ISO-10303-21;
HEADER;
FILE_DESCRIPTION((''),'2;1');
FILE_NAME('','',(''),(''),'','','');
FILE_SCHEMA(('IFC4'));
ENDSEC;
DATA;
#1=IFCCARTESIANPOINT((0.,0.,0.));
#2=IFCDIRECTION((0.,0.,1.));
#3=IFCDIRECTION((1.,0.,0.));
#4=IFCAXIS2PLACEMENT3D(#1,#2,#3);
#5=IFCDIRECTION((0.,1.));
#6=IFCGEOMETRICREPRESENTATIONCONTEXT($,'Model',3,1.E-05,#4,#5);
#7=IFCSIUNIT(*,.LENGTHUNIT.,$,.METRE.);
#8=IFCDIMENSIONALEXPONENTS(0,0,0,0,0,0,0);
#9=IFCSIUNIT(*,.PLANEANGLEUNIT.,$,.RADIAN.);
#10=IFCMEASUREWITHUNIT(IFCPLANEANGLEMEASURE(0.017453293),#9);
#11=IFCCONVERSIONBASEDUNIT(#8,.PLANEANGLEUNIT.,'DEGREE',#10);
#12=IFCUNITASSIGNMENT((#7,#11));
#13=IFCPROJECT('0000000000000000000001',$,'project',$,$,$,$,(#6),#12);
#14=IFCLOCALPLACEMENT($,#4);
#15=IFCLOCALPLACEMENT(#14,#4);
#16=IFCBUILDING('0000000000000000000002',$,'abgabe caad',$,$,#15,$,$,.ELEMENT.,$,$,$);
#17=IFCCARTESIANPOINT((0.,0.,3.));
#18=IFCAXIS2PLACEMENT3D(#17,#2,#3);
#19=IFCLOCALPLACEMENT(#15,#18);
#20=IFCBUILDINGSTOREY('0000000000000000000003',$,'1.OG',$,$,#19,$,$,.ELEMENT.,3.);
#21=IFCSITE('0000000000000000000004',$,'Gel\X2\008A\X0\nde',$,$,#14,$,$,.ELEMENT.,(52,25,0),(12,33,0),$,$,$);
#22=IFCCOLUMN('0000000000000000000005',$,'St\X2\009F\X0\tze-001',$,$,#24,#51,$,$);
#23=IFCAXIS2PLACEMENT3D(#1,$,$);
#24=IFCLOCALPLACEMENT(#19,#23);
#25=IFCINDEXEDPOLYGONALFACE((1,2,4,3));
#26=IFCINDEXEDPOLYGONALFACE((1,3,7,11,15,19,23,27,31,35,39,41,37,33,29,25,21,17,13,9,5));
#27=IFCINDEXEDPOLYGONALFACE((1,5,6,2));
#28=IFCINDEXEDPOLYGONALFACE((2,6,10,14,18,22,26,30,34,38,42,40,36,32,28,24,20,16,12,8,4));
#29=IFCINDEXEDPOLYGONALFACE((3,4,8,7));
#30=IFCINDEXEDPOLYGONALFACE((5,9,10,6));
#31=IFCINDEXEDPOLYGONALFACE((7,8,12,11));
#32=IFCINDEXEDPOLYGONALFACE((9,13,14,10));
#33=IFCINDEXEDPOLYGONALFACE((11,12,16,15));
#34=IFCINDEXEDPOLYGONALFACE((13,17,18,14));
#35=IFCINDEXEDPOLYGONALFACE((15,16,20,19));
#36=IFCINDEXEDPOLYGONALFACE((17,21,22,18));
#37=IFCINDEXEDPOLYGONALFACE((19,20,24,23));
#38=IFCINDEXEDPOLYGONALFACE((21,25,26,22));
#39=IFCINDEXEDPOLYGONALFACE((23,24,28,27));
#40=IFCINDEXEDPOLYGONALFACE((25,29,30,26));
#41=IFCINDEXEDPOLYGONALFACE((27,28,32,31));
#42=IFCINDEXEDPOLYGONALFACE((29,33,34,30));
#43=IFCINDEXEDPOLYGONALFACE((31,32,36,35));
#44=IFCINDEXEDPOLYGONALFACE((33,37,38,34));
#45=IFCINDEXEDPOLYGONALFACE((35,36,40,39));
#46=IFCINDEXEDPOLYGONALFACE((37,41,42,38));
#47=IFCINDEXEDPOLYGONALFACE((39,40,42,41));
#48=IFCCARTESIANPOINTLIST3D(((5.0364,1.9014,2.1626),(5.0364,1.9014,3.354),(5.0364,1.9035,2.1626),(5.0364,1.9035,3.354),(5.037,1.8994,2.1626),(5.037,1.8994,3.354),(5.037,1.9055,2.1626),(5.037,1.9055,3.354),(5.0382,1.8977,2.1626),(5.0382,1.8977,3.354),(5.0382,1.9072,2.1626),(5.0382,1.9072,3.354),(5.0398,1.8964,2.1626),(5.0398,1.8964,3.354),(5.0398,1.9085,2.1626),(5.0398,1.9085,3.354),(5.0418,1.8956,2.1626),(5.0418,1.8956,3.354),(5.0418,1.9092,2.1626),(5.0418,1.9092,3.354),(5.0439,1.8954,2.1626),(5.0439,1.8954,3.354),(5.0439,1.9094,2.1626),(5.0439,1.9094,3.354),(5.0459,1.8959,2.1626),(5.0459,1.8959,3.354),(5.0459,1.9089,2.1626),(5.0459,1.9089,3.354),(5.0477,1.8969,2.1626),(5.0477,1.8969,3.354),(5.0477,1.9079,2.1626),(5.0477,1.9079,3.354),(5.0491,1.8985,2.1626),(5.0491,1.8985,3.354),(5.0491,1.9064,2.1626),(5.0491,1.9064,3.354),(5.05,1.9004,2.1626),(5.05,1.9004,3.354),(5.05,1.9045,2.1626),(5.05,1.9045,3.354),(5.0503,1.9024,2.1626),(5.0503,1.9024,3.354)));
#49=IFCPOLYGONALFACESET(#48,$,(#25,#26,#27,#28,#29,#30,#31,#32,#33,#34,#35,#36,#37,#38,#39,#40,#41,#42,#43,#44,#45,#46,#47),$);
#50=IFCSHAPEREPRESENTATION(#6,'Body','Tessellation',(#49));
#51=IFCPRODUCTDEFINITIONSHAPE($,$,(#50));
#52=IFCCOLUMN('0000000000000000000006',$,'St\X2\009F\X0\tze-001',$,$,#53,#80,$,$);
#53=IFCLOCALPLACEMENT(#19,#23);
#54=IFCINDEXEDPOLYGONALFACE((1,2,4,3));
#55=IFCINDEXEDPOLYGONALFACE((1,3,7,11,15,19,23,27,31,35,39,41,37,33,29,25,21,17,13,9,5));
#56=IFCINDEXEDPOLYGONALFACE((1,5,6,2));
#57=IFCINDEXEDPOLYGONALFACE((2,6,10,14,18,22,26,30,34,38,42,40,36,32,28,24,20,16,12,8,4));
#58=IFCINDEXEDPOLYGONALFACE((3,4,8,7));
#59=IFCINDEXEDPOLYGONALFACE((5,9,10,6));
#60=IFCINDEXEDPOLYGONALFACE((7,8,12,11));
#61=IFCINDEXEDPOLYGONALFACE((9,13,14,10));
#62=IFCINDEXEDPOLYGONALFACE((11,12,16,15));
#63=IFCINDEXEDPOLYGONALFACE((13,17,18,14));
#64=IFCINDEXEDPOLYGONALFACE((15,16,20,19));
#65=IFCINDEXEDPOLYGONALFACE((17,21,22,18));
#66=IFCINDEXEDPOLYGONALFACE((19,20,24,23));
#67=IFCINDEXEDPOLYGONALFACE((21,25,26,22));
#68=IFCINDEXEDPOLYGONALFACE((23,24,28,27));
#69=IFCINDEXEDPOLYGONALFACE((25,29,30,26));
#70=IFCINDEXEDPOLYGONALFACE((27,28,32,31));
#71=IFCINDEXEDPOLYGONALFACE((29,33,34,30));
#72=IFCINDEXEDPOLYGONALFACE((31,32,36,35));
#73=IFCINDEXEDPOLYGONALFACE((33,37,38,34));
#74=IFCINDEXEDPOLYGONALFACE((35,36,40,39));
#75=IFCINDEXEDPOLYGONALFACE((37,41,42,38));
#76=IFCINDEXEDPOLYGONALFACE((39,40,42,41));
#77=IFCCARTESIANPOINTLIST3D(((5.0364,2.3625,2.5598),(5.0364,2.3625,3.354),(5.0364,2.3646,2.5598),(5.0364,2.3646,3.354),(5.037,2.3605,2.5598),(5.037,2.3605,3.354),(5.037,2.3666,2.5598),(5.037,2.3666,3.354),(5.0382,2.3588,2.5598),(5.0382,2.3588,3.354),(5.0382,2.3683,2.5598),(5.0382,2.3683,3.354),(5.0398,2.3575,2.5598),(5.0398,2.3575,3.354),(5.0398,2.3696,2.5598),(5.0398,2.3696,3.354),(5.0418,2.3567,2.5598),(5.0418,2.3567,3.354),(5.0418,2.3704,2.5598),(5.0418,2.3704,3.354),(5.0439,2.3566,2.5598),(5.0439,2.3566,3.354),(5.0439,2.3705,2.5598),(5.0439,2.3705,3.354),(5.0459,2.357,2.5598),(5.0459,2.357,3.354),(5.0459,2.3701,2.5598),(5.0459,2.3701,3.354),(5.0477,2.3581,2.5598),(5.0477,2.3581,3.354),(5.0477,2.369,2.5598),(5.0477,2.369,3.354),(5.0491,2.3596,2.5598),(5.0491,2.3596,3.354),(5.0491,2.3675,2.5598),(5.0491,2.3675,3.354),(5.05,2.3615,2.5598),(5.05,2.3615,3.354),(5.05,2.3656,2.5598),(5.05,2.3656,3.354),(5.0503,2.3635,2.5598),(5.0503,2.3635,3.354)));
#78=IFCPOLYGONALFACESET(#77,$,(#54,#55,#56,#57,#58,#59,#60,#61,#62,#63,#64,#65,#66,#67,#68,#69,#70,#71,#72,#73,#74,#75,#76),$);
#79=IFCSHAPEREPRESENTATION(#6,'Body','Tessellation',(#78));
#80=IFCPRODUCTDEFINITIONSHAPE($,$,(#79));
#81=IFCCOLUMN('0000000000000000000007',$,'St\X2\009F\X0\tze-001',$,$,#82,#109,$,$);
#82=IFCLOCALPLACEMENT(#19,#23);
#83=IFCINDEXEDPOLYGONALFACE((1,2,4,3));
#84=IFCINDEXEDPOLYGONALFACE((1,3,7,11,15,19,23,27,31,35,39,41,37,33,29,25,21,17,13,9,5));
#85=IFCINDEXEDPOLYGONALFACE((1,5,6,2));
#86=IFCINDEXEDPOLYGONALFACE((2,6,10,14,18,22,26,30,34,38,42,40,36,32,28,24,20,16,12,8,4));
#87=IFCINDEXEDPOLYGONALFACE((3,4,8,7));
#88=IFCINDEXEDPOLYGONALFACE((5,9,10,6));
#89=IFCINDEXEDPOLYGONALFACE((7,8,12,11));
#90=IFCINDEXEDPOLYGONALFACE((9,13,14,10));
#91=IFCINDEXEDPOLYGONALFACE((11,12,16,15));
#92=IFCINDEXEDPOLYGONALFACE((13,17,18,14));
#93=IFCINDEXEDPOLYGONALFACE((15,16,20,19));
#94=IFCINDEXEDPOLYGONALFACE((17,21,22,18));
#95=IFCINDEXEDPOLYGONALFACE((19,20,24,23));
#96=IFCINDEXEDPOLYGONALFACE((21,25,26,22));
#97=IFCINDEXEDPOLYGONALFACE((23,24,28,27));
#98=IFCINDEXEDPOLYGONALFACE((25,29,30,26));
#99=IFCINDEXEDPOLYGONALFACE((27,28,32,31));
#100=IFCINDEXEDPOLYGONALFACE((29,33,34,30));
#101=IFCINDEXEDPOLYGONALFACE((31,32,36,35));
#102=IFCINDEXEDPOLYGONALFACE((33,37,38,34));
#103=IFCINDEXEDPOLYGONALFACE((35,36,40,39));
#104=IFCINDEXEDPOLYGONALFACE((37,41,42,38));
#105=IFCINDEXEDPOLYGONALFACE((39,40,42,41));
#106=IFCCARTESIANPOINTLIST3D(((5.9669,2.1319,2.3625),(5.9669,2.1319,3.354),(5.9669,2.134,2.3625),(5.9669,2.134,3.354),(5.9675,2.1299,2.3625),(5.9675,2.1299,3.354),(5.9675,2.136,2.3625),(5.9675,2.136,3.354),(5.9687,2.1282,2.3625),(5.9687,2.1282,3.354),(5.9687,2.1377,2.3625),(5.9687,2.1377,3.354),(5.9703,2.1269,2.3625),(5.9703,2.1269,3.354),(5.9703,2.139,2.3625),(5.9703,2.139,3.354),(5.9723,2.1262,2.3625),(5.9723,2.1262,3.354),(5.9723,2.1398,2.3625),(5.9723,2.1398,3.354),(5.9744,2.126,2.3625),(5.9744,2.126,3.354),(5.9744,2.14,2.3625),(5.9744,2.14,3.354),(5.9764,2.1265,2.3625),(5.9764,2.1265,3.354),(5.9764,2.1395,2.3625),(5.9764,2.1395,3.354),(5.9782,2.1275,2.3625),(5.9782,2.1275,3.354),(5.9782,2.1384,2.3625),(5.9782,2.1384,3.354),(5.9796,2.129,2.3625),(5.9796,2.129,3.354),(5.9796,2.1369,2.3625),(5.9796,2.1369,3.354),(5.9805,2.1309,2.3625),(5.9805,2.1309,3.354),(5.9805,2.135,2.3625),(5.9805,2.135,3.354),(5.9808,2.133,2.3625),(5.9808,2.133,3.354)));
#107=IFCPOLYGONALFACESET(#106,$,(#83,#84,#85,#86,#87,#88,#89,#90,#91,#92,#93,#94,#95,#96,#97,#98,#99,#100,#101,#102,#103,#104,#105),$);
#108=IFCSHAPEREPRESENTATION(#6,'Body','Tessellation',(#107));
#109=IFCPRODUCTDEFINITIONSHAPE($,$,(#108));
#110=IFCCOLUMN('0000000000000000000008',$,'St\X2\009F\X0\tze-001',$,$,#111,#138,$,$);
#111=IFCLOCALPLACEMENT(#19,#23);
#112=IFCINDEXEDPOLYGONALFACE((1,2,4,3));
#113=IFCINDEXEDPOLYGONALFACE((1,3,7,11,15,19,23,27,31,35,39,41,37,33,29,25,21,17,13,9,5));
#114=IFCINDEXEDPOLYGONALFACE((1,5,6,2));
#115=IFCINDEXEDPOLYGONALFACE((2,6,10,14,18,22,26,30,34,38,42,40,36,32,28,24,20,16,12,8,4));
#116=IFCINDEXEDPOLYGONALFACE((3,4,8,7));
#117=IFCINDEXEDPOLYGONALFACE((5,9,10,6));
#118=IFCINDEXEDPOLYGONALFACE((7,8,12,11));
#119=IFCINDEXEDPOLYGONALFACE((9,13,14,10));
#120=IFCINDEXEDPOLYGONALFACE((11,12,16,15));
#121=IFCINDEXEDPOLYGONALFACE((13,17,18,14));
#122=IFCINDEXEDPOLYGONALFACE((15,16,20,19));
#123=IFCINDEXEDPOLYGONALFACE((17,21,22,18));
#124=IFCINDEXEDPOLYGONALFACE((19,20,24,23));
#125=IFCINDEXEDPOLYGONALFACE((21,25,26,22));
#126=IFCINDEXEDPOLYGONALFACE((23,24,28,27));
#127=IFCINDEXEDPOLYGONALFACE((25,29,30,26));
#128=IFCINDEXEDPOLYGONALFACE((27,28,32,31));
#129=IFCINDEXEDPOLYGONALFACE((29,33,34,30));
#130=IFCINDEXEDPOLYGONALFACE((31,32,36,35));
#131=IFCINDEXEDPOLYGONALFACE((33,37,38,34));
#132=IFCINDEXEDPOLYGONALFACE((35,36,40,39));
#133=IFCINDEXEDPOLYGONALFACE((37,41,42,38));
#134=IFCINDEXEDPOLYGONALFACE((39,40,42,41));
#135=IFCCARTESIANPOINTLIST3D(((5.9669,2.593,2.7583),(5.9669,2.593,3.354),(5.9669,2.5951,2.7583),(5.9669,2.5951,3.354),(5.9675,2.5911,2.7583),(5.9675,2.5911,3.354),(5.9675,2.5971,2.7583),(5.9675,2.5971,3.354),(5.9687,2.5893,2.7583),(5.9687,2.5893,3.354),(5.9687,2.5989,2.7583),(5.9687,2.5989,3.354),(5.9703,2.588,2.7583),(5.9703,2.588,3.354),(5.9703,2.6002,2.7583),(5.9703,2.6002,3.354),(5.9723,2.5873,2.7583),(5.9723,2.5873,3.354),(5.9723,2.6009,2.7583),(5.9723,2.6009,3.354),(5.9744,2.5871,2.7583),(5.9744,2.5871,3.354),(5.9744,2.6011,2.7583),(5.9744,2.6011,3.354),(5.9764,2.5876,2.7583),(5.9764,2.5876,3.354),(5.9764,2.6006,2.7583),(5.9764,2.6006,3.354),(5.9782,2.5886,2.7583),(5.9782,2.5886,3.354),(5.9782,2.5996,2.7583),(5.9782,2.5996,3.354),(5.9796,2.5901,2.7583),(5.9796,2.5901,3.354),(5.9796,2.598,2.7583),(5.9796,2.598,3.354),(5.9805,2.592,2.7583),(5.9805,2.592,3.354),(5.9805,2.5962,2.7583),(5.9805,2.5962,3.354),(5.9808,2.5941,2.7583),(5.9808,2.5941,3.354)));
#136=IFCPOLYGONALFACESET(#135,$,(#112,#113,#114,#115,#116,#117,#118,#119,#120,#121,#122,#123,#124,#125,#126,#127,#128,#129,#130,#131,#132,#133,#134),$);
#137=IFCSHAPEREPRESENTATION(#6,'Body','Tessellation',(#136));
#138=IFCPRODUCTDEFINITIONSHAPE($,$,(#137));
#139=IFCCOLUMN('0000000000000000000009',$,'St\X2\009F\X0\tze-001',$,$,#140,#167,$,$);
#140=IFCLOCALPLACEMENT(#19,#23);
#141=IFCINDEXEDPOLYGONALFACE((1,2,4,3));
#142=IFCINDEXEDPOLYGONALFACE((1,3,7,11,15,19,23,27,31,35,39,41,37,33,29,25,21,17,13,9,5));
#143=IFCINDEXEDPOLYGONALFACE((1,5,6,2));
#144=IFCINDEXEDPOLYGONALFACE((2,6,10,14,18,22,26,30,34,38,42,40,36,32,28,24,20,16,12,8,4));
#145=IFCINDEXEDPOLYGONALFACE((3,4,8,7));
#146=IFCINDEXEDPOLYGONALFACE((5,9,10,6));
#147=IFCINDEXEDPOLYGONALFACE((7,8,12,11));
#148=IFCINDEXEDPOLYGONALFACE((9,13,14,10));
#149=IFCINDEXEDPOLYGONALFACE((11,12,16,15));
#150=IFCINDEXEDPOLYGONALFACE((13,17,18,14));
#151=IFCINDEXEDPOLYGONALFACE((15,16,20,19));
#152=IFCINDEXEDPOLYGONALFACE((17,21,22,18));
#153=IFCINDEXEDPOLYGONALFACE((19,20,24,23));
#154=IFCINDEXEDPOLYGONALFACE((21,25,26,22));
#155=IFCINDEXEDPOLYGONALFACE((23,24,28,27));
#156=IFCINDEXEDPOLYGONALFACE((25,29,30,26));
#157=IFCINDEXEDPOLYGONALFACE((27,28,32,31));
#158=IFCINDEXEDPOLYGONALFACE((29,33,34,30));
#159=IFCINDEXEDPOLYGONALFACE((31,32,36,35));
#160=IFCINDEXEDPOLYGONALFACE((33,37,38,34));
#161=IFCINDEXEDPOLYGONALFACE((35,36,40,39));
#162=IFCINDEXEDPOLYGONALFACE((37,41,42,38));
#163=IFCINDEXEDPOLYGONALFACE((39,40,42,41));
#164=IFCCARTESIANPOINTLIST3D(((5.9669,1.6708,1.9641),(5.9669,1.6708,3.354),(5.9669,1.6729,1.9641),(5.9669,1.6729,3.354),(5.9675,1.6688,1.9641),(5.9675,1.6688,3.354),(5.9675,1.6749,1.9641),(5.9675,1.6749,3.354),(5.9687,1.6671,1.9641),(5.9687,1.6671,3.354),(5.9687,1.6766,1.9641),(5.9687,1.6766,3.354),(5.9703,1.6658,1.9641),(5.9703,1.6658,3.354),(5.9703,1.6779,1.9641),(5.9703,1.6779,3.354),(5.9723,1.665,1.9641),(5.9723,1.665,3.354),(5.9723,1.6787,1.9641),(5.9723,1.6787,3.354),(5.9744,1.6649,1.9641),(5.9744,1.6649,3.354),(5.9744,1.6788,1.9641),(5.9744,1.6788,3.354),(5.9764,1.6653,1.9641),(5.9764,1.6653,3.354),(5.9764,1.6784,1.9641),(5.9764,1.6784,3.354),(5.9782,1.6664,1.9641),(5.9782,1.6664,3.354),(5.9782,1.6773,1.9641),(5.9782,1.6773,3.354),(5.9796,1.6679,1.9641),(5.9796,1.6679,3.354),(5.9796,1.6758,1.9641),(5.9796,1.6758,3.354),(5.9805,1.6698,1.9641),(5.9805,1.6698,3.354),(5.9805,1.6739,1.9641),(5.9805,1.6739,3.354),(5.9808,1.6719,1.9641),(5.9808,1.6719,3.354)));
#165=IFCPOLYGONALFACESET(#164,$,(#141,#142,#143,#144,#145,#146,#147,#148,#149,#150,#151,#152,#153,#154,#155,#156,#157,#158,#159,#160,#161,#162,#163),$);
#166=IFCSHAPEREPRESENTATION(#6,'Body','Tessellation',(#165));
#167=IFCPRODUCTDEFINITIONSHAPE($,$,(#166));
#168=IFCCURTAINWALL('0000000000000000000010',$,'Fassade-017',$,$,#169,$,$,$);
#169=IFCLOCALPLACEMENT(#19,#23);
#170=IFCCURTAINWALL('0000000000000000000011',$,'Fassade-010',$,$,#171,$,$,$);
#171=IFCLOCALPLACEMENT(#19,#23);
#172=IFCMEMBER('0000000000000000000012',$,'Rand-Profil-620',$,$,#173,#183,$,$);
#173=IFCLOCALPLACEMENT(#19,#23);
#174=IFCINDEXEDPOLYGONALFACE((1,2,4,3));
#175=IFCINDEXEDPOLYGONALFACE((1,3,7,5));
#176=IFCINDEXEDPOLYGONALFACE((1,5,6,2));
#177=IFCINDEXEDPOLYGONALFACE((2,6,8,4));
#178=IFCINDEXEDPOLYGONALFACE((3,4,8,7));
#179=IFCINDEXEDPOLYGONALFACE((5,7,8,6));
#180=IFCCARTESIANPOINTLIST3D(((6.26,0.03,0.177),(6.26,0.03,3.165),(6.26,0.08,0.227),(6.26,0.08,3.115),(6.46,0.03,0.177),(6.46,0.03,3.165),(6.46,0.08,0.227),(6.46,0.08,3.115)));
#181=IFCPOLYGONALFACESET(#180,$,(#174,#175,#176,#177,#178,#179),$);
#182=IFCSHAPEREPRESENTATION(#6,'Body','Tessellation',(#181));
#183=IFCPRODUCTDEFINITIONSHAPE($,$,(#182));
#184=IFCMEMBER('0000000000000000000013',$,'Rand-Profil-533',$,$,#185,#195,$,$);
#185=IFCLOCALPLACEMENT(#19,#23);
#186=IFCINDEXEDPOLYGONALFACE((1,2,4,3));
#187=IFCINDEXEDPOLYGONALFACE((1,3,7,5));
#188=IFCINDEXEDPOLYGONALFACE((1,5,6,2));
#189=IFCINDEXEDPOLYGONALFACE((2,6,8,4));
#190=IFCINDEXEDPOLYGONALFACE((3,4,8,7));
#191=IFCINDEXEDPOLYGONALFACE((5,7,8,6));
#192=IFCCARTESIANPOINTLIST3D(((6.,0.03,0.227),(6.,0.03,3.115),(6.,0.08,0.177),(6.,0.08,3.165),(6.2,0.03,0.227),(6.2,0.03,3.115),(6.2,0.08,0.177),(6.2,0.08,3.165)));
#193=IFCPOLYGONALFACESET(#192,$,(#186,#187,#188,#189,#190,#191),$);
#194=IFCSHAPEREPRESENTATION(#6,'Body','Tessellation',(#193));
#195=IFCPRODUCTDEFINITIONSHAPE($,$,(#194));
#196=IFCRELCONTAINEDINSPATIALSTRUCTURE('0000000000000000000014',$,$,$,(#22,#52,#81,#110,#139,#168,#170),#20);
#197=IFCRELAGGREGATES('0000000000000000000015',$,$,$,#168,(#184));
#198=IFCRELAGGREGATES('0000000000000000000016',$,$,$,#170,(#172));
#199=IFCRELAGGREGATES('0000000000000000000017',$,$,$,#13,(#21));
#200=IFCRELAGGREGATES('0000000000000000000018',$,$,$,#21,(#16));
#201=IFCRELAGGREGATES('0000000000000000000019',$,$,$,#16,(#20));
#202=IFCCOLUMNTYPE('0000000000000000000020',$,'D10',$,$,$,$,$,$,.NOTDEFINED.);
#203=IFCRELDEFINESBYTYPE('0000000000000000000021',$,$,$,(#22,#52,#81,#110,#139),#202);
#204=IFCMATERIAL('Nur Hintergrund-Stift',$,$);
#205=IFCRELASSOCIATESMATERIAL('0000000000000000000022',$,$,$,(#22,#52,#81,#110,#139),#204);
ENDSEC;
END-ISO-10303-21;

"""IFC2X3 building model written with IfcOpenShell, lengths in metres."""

from ifc_helpers import new_model, entity, si_unit, converted_unit, direction, frame, origin_with_axes, origin_2d_with_axis, place, context, project, spatial, polyline, circle, outline, extrude, clip, halfspace, material, type_object, element, aggregate, save


model = new_model("IFC2X3")

# Units and contexts
model_context = context("Model", 3, precision=1e-05, world=origin_with_axes(), true_north=direction((0.0, 1.0)))
ifc_project = project(units=[si_unit("LENGTHUNIT", "METRE"), converted_unit("PLANEANGLEUNIT", "DEGREE", entity("IfcPlaneAngleMeasure", 0.017453293), si_unit("PLANEANGLEUNIT", "RADIAN"), dimensions=[0, 0, 0, 0, 0, 0, 0])], contexts=[model_context])

# Site, building, storey
site_placement = place(None, origin_with_axes())
site = spatial("IfcSite", under=ifc_project, at=site_placement, Name="Gel\u008ande", CompositionType="ELEMENT", RefLatitude=(52, 25, 0), RefLongitude=(12, 33, 0))
building_placement = place(site_placement, origin_with_axes())
building = spatial("IfcBuilding", under=site, at=building_placement, Name="abgabe caad", CompositionType="ELEMENT")
storey_placement = place(building_placement, frame((0.0, 0.0, 3.0), z_axis=(0.0, 0.0, 1.0), x_axis=(1.0, 0.0, 0.0)))
storey = spatial("IfcBuildingStorey", under=building, at=storey_placement, Name="1.OG", CompositionType="ELEMENT", Elevation=3.0)

# Columns
ifc_material_1 = material(Name="Nur Hintergrund-Stift")
column_type = type_object("IfcColumnType", Name="D10", PredefinedType="NOTDEFINED")
column_1_placement = place(storey_placement, frame((5.0433, 1.9024, 2.1626), z_axis=(0.0, 0.0, 1.0), x_axis=(1.0, 0.0, 0.0)))
element("IfcColumn", 1, at=column_1_placement, inside=storey, type_object=column_type, material=ifc_material_1, Name="St\u009ftze-001", context=model_context, shape_type="SweptSolid", body=[
    extrude(circle(Radius=0.007, at=origin_2d_with_axis()), origin_with_axes(), (0.0, 0.0, 1.0), 1.1914),
])
column_2_placement = place(storey_placement, frame((5.0433, 2.3635, 2.5598), z_axis=(0.0, 0.0, 1.0), x_axis=(1.0, 0.0, 0.0)))
element("IfcColumn", 2, at=column_2_placement, inside=storey, type_object=column_type, material=ifc_material_1, Name="St\u009ftze-001", context=model_context, shape_type="SweptSolid", body=[
    extrude(circle(Radius=0.007, at=origin_2d_with_axis()), origin_with_axes(), (0.0, 0.0, 1.0), 0.7943),
])
column_3_placement = place(storey_placement, frame((5.9738, 2.133, 2.3625), z_axis=(0.0, 0.0, 1.0), x_axis=(1.0, 0.0, 0.0)))
element("IfcColumn", 3, at=column_3_placement, inside=storey, type_object=column_type, material=ifc_material_1, Name="St\u009ftze-001", context=model_context, shape_type="SweptSolid", body=[
    extrude(circle(Radius=0.007, at=origin_2d_with_axis()), origin_with_axes(), (0.0, 0.0, 1.0), 0.9915),
])
column_4_placement = place(storey_placement, frame((5.9738, 2.5941, 2.7583), z_axis=(0.0, 0.0, 1.0), x_axis=(1.0, 0.0, 0.0)))
element("IfcColumn", 4, at=column_4_placement, inside=storey, type_object=column_type, material=ifc_material_1, Name="St\u009ftze-001", context=model_context, shape_type="SweptSolid", body=[
    extrude(circle(Radius=0.007, at=origin_2d_with_axis()), origin_with_axes(), (0.0, 0.0, 1.0), 0.5957),
])
column_5_placement = place(storey_placement, frame((5.9738, 1.6719, 1.9641), z_axis=(0.0, 0.0, 1.0), x_axis=(1.0, 0.0, 0.0)))
element("IfcColumn", 5, at=column_5_placement, inside=storey, type_object=column_type, material=ifc_material_1, Name="St\u009ftze-001", context=model_context, shape_type="SweptSolid", body=[
    extrude(circle(Radius=0.007, at=origin_2d_with_axis()), origin_with_axes(), (0.0, 0.0, 1.0), 1.3899),
])

# Curtain wall
curtain_wall_1_placement = place(storey_placement, frame((5.595, 0.055, 0.202), z_axis=(0.0, 0.0, 1.0), x_axis=(1.0, 0.0, 0.0)))
curtain_wall_1 = element("IfcCurtainWall", 6, at=curtain_wall_1_placement, inside=storey, Name="Fassade-017")

# Curtain wall
curtain_wall_2_placement = place(storey_placement, frame((9.205, 0.055, 0.202), z_axis=(0.0, 0.0, 1.0), x_axis=(1.0, 0.0, 0.0)))
curtain_wall_2 = element("IfcCurtainWall", 7, at=curtain_wall_2_placement, inside=storey, Name="Fassade-010")

# Members
member_1_placement = place(curtain_wall_2_placement, frame((-2.8, 0.0, 0.0), z_axis=(0.0, 0.0, 1.0), x_axis=(0.0, -1.0, 0.0)))
member_1 = element("IfcMember", 8, at=member_1_placement, Name="Rand-Profil-620", context=model_context, shape_type="Clipping", body=[
    clip(clip(extrude(outline(polyline([(-0.145, -0.025), (0.055, -0.025), (0.055, 0.025), (-0.145, 0.025), (-0.145, -0.025)])), frame((0.0, 0.0, -0.025), z_axis=(0.0, 0.0, 1.0), x_axis=(0.0, 1.0, 0.0)), (0.0, 0.0, 1.0), 2.988), halfspace(frame((0.0, 0.0, 0.0), z_axis=(0.707107, 0.0, 0.707107), x_axis=(-0.707107, 0.0, 0.707107)), True)), halfspace(frame((-1.469, 0.0, 1.469), z_axis=(0.707107, 0.0, -0.707107), x_axis=(0.707107, 0.0, 0.707107)), True)),
])
member_2_placement = place(curtain_wall_1_placement, frame((0.55, 0.0, 0.0), z_axis=(0.0, 0.0, 1.0), x_axis=(0.0, -1.0, 0.0)))
member_2 = element("IfcMember", 9, at=member_2_placement, Name="Rand-Profil-533", context=model_context, shape_type="Clipping", body=[
    clip(clip(extrude(outline(polyline([(-0.145, -0.025), (0.055, -0.025), (0.055, 0.025), (-0.145, 0.025), (-0.145, -0.025)])), frame((0.0, 0.0, -0.025), z_axis=(0.0, 0.0, 1.0), x_axis=(0.0, 1.0, 0.0)), (0.0, 0.0, 1.0), 2.988), halfspace(frame((0.0, 0.0, 0.0), z_axis=(-0.707107, 0.0, 0.707107), x_axis=(-0.707107, 0.0, -0.707107)), True)), halfspace(frame((1.469, 0.0, 1.469), z_axis=(-0.707107, 0.0, -0.707107), x_axis=(0.707107, 0.0, -0.707107)), True)),
])

aggregate(curtain_wall_1, [member_2])
aggregate(curtain_wall_2, [member_1])

save(model, "model.ifc")
